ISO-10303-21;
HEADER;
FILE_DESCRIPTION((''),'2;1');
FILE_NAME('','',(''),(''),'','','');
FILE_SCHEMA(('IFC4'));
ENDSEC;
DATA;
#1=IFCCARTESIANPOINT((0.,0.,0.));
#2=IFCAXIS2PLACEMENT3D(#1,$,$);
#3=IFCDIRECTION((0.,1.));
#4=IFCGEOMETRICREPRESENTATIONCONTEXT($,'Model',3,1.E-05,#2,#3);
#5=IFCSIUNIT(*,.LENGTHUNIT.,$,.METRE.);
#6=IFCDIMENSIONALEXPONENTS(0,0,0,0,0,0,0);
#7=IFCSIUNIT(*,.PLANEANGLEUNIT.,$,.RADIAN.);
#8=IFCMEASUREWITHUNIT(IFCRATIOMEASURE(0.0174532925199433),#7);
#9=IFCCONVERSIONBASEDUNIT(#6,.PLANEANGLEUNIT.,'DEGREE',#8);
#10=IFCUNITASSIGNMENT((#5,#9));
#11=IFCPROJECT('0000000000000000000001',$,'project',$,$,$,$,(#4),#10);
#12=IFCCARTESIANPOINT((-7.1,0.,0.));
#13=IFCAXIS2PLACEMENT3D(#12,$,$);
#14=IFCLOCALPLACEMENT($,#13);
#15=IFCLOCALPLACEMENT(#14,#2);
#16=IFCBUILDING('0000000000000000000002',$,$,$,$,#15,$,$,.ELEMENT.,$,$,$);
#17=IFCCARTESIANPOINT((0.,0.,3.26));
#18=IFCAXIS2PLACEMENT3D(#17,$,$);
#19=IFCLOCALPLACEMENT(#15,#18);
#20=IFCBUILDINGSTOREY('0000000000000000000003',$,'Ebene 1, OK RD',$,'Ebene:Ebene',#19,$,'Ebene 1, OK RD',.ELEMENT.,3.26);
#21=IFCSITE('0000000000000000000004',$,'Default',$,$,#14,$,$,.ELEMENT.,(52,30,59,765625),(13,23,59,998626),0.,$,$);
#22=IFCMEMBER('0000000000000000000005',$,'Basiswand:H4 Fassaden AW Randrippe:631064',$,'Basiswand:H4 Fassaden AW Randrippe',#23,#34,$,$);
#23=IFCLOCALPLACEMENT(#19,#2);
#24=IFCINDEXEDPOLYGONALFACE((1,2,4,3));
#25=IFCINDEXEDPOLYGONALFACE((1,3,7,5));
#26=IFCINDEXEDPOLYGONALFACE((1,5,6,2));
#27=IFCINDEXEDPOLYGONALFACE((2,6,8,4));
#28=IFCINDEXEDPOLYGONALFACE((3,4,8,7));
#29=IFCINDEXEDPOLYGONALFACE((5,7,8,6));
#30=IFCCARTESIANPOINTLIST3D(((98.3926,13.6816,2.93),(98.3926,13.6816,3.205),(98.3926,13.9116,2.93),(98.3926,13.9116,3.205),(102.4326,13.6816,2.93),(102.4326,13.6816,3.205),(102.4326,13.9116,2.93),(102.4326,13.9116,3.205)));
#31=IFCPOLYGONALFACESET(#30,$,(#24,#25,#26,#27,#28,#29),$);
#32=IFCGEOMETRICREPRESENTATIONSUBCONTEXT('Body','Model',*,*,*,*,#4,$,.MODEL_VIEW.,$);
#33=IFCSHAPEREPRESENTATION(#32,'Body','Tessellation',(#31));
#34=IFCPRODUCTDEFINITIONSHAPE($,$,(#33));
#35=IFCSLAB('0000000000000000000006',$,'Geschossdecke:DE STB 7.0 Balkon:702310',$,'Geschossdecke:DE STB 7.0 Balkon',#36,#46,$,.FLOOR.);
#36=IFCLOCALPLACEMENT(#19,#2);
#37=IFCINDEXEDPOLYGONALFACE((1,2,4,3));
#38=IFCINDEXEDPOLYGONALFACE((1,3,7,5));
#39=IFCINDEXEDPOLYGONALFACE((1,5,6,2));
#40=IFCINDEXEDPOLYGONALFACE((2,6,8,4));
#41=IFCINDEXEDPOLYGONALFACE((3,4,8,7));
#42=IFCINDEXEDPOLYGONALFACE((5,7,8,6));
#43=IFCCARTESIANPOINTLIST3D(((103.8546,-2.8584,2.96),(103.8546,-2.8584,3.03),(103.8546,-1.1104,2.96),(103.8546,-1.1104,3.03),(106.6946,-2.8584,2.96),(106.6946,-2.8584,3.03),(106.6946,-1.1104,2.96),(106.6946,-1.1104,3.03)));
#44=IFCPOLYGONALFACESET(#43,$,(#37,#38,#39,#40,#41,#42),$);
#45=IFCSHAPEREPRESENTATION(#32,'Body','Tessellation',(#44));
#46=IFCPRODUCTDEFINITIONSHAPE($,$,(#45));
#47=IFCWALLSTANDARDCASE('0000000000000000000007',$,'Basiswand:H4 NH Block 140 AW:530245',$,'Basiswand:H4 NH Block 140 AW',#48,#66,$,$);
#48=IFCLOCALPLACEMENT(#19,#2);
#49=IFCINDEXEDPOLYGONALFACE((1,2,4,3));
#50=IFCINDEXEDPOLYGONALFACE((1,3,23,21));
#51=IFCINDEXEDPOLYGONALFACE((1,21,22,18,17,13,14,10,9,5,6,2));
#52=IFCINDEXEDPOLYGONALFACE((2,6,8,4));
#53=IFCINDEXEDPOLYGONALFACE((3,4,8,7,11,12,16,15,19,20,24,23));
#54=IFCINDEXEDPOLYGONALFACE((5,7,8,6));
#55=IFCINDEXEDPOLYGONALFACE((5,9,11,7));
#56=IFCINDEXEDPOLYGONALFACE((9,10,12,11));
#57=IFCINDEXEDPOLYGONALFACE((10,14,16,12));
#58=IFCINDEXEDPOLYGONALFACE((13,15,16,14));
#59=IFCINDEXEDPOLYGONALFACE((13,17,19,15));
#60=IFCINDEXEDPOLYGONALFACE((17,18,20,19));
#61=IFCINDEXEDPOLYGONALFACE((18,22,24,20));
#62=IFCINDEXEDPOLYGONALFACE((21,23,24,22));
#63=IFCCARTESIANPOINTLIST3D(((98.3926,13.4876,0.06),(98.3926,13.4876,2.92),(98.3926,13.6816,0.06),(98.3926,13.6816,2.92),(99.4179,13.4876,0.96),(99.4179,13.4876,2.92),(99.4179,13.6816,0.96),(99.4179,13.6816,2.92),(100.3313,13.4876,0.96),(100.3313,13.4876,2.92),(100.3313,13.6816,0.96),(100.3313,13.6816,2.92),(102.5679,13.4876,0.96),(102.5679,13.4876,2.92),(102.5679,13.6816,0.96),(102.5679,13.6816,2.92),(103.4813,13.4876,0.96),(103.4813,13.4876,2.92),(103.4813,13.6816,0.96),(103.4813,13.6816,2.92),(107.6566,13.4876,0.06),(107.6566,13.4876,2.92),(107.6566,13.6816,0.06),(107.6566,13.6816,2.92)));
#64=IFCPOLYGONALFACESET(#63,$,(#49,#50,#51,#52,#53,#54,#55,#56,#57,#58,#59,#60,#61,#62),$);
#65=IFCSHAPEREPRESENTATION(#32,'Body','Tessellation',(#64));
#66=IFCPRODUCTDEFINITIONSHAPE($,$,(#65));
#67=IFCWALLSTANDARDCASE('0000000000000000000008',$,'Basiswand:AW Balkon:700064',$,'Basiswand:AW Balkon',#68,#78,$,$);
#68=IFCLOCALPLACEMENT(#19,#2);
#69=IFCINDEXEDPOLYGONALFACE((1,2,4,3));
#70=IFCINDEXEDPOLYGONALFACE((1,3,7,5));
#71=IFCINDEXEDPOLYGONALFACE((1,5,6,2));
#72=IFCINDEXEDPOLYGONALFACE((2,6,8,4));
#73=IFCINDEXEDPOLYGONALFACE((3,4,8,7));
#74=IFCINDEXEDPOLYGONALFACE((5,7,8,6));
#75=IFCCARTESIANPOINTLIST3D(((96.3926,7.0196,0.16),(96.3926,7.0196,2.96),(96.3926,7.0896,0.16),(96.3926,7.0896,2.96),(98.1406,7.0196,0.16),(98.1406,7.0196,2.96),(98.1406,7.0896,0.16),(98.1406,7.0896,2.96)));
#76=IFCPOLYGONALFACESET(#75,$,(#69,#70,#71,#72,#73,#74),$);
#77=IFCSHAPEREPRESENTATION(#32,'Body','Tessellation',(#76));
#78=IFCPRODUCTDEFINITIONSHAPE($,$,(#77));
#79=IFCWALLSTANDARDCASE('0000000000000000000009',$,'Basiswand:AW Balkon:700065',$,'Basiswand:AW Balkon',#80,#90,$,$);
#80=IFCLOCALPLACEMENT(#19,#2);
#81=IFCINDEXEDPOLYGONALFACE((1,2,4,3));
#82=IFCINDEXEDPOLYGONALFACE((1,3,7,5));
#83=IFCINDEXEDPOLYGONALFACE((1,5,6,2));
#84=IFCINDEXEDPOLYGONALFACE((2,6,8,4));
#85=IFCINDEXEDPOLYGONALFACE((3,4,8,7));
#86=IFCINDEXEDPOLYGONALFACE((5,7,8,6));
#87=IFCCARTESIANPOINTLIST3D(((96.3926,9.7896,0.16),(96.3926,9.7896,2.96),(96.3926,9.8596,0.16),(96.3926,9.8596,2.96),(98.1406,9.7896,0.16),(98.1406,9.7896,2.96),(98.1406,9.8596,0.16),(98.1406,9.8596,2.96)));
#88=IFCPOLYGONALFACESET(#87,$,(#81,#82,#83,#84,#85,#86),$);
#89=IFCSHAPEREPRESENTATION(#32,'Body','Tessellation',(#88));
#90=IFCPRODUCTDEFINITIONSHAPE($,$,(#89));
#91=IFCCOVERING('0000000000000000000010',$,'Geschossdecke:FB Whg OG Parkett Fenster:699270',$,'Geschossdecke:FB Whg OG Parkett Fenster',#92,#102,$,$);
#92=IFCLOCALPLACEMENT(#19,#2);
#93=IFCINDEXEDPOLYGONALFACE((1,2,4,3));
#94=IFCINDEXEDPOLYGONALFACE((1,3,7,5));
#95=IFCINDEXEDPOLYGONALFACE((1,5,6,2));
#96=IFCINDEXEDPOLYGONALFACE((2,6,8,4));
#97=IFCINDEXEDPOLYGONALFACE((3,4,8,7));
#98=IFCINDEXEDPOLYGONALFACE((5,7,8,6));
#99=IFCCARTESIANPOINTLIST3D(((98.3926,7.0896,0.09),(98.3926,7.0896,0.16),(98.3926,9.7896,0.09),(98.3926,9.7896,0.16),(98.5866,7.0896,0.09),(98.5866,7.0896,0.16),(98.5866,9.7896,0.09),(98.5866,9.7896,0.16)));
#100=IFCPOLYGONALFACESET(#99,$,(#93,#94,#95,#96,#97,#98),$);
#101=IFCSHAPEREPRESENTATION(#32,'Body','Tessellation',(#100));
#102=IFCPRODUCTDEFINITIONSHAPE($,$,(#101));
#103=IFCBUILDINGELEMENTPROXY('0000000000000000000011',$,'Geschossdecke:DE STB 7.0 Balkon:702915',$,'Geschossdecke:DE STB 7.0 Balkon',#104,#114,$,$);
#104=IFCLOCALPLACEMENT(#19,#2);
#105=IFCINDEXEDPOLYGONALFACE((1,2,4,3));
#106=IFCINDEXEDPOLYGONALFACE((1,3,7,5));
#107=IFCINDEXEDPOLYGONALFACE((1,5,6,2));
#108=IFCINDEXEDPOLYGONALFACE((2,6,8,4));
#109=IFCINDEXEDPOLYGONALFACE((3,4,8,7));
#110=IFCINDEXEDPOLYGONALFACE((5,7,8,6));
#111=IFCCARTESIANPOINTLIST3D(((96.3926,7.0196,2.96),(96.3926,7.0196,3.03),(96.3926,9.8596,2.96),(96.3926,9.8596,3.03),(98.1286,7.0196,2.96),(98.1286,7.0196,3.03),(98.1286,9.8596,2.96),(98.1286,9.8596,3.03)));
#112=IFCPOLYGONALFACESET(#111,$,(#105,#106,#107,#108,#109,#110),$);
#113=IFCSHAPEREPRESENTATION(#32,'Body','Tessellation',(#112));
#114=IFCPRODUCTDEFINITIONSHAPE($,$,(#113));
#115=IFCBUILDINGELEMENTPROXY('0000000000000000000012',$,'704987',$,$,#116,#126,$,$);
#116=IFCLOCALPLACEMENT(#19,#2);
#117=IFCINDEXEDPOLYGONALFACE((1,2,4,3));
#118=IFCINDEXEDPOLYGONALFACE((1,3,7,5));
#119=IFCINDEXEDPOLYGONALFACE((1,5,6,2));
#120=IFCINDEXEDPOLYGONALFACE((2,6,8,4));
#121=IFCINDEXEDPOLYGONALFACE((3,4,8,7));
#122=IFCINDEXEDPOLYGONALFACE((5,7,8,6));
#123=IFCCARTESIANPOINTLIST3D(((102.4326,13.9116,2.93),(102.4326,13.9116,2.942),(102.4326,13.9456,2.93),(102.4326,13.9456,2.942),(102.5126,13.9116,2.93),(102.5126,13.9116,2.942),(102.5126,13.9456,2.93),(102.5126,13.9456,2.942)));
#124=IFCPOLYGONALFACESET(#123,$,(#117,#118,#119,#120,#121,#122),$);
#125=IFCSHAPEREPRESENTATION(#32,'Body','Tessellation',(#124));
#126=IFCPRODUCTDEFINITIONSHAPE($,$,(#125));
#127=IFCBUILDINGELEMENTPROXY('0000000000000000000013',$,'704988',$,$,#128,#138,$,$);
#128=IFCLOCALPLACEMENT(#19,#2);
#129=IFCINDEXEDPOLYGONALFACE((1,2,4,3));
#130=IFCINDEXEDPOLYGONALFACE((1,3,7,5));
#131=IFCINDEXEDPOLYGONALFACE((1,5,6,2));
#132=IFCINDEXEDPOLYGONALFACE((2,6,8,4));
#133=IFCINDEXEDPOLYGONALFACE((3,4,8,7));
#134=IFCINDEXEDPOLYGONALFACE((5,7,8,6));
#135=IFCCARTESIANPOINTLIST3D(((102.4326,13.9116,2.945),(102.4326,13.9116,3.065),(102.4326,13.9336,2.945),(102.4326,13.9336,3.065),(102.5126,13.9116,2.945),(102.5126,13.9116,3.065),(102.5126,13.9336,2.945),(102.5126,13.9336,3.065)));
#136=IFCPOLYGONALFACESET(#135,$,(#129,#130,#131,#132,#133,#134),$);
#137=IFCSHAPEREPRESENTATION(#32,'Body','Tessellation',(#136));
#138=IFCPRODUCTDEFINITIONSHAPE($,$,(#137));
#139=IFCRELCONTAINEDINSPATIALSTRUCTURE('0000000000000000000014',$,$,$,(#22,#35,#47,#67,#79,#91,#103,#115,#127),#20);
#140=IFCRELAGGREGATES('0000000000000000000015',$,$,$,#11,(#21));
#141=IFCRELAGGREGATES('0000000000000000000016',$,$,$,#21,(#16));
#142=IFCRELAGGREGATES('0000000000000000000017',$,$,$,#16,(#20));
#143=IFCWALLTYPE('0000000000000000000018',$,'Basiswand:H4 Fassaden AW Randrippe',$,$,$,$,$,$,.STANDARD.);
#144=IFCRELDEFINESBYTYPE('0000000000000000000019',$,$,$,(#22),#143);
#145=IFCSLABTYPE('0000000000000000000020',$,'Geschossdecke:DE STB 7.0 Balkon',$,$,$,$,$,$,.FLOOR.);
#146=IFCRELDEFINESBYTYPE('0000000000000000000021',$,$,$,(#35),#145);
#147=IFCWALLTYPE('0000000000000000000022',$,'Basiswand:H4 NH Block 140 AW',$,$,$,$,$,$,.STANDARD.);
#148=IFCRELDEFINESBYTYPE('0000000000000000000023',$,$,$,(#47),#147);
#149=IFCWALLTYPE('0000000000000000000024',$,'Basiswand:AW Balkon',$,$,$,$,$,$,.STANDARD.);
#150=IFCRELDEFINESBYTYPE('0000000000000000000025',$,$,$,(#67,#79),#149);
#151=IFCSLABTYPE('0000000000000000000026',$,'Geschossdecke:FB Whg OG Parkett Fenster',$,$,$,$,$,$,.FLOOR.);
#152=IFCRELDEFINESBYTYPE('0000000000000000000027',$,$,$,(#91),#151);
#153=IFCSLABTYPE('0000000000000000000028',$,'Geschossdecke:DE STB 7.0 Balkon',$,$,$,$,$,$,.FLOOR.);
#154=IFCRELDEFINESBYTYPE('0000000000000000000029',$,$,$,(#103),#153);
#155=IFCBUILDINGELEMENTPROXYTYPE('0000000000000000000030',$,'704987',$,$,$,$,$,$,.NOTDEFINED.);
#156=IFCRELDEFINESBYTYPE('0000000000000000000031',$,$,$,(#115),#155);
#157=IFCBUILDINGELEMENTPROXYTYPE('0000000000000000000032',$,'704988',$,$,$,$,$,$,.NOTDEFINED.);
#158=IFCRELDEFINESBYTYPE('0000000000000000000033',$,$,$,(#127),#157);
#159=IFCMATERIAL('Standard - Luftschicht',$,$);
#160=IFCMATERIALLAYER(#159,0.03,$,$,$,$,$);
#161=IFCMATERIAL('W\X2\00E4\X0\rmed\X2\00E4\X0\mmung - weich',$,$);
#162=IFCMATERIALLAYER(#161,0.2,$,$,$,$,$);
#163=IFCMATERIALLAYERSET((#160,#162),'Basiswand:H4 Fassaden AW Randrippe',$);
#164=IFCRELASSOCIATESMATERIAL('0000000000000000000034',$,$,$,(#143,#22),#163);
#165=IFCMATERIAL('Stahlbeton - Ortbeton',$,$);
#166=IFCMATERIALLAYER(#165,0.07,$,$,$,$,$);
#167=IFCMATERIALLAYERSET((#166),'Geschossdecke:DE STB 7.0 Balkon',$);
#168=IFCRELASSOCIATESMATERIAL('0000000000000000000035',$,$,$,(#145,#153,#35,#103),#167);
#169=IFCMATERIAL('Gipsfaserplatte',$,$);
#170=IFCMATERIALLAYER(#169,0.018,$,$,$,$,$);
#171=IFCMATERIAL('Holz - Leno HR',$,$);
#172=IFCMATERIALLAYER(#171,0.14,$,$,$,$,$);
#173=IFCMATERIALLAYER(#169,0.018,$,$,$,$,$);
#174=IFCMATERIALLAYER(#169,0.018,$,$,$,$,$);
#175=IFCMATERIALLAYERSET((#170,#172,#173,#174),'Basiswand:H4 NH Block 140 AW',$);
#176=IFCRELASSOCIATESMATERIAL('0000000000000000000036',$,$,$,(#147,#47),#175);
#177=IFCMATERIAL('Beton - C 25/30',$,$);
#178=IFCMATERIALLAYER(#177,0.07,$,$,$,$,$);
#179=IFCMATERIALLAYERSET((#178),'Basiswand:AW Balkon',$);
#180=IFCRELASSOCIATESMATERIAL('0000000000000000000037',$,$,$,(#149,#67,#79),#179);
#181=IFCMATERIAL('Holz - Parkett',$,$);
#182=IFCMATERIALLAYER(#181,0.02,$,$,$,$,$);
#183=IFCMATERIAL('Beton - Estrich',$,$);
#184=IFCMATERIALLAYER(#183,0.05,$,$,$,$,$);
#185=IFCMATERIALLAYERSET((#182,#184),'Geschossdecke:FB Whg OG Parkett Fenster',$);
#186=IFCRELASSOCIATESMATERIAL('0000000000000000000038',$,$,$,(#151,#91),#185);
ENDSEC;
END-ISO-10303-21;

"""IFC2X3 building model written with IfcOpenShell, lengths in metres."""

from ifc_helpers import new_model, entity, si_unit, converted_unit, direction, frame, frame_2d, origin, origin_2d_with_axis, place, context, subcontext, project, spatial, rectangle, extrude, material, layer, layer_set, layer_usage, type_object, element, save


model = new_model("IFC2X3")

# Units and contexts
model_context = context("Model", 3, precision=1e-05, world=origin(), true_north=direction((0.0, 1.0)))
body_context = subcontext(model_context, "Body", "Model", "MODEL_VIEW")
ifc_project = project(units=[si_unit("LENGTHUNIT", "METRE"), converted_unit("PLANEANGLEUNIT", "DEGREE", entity("IfcRatioMeasure", 0.0174532925199433), si_unit("PLANEANGLEUNIT", "RADIAN"), dimensions=[0, 0, 0, 0, 0, 0, 0])], contexts=[model_context])

# Site, building, storey
site_placement = place(None, frame((-7.1, 0.0, 0.0)))
site = spatial("IfcSite", under=ifc_project, at=site_placement, Name="Default", CompositionType="ELEMENT", RefLatitude=(52, 30, 59, 765625), RefLongitude=(13, 23, 59, 998626), RefElevation=0.0)
building_placement = place(site_placement, origin())
building = spatial("IfcBuilding", under=site, at=building_placement, CompositionType="ELEMENT")
storey_placement = place(building_placement, frame((0.0, 0.0, 3.26)))
storey = spatial("IfcBuildingStorey", under=building, at=storey_placement, Name="Ebene 1, OK RD", ObjectType="Ebene:Ebene", LongName="Ebene 1, OK RD", CompositionType="ELEMENT", Elevation=3.26)

# Shared definitions
ifc_material_1 = material(Name="Gipsfaserplatte")

# Member
ifc_material_2 = material(Name="Standard - Luftschicht")
ifc_layer_1 = layer(ifc_material_2, 0.03)
ifc_material_3 = material(Name="Wärmedämmung - weich")
ifc_layer_2 = layer(ifc_material_3, 0.2)
ifc_layer_set_1 = layer_set([ifc_layer_1, ifc_layer_2], Name="Basiswand:H4 Fassaden AW Randrippe")
ifc_layer_usage_1 = layer_usage(ifc_layer_set_1, "AXIS2", "NEGATIVE", 0.115)
wall_type_1 = type_object("IfcWallType", Name="Basiswand:H4 Fassaden AW Randrippe", PredefinedType="STANDARD", material=ifc_layer_set_1)
member_1_placement = place(storey_placement, frame((98.3926, 13.7966, 2.93)))
element("IfcMember", 1, at=member_1_placement, inside=storey, type_object=wall_type_1, material=ifc_layer_usage_1, Name="Basiswand:H4 Fassaden AW Randrippe:631064", ObjectType="Basiswand:H4 Fassaden AW Randrippe", context=body_context, shape_type="SweptSolid", body=[
    extrude(rectangle(XDim=4.04, YDim=0.23, at=frame_2d((2.02, 0.0), x_axis=(-1.0, 0.0))), origin(), (0.0, 0.0, 1.0), 0.275),
])

# Slab
ifc_material_4 = material(Name="Stahlbeton - Ortbeton")
ifc_layer_3 = layer(ifc_material_4, 0.07)
ifc_layer_set_2 = layer_set([ifc_layer_3], Name="Geschossdecke:DE STB 7.0 Balkon")
ifc_layer_usage_2 = layer_usage(ifc_layer_set_2, "AXIS3", "POSITIVE", 0.0)
slab_type_1 = type_object("IfcSlabType", Name="Geschossdecke:DE STB 7.0 Balkon", PredefinedType="FLOOR", material=ifc_layer_set_2)
slab_1_placement = place(storey_placement, origin())
element("IfcSlab", 2, at=slab_1_placement, inside=storey, type_object=slab_type_1, material=ifc_layer_usage_2, Name="Geschossdecke:DE STB 7.0 Balkon:702310", ObjectType="Geschossdecke:DE STB 7.0 Balkon", PredefinedType="FLOOR", context=body_context, shape_type="SweptSolid", body=[
    extrude(rectangle(XDim=1.748, YDim=2.84, at=frame_2d((0.0, 0.0), x_axis=(1.0, 0.0))), frame((105.2746, -1.9844, 3.03), z_axis=(0.0, 0.0, -1.0), x_axis=(0.0, 1.0, 0.0)), (0.0, 0.0, 1.0), 0.07),
])

# Wall, openings
ifc_layer_4 = layer(ifc_material_1, 0.018)
ifc_material_5 = material(Name="Holz - Leno HR")
ifc_layer_5 = layer(ifc_material_5, 0.14)
ifc_layer_6 = layer(ifc_material_1, 0.018)
ifc_layer_7 = layer(ifc_material_1, 0.018)
ifc_layer_set_3 = layer_set([ifc_layer_4, ifc_layer_5, ifc_layer_6, ifc_layer_7], Name="Basiswand:H4 NH Block 140 AW")
ifc_layer_usage_3 = layer_usage(ifc_layer_set_3, "AXIS2", "NEGATIVE", 0.097)
wall_type_2 = type_object("IfcWallType", Name="Basiswand:H4 NH Block 140 AW", PredefinedType="STANDARD", material=ifc_layer_set_3)
wall_1_placement = place(storey_placement, frame((98.3926, 13.5846, 0.06)))
wall_1 = element("IfcWallStandardCase", 3, at=wall_1_placement, inside=storey, type_object=wall_type_2, material=ifc_layer_usage_3, Name="Basiswand:H4 NH Block 140 AW:530245", ObjectType="Basiswand:H4 NH Block 140 AW", context=body_context, shape_type="SweptSolid", body=[
    extrude(rectangle(XDim=9.264, YDim=0.194, at=frame_2d((4.632, 0.0), x_axis=(-1.0, 0.0))), origin(), (0.0, 0.0, 1.0), 2.86),
])
opening_1_placement = place(wall_1_placement, origin())
element("IfcOpeningElement", 4, at=opening_1_placement, cuts=wall_1, ObjectType="Opening", context=body_context, shape_type="SweptSolid", body=[
    extrude(rectangle(XDim=2.0, YDim=0.9134, at=origin_2d_with_axis()), frame((1.482, -0.097, 1.9), z_axis=(0.0, 1.0, 0.0), x_axis=(0.0, 0.0, -1.0)), (0.0, 0.0, 1.0), 0.194),
])
opening_2_placement = place(wall_1_placement, origin())
element("IfcOpeningElement", 5, at=opening_2_placement, cuts=wall_1, ObjectType="Opening", context=body_context, shape_type="SweptSolid", body=[
    extrude(rectangle(XDim=2.0, YDim=0.9134, at=origin_2d_with_axis()), frame((4.632, -0.097, 1.9), z_axis=(0.0, 1.0, 0.0), x_axis=(0.0, 0.0, -1.0)), (0.0, 0.0, 1.0), 0.194),
])

# Walls
ifc_material_6 = material(Name="Beton - C 25/30")
ifc_layer_8 = layer(ifc_material_6, 0.07)
ifc_layer_set_4 = layer_set([ifc_layer_8], Name="Basiswand:AW Balkon")
ifc_layer_usage_4 = layer_usage(ifc_layer_set_4, "AXIS2", "NEGATIVE", 0.035)
wall_type_3 = type_object("IfcWallType", Name="Basiswand:AW Balkon", PredefinedType="STANDARD", material=ifc_layer_set_4)
wall_2_placement = place(storey_placement, frame((98.1406, 7.0546, 0.16), z_axis=(0.0, 0.0, 1.0), x_axis=(-1.0, 0.0, 0.0)))
element("IfcWallStandardCase", 6, at=wall_2_placement, inside=storey, type_object=wall_type_3, material=ifc_layer_usage_4, Name="Basiswand:AW Balkon:700064", ObjectType="Basiswand:AW Balkon", context=body_context, shape_type="SweptSolid", body=[
    extrude(rectangle(XDim=1.748, YDim=0.07, at=frame_2d((0.874, 0.0), x_axis=(-1.0, 0.0))), origin(), (0.0, 0.0, 1.0), 2.8),
])
ifc_layer_usage_5 = layer_usage(ifc_layer_set_4, "AXIS2", "NEGATIVE", 0.035)
wall_3_placement = place(storey_placement, frame((96.3926, 9.8246, 0.16)))
element("IfcWallStandardCase", 7, at=wall_3_placement, inside=storey, type_object=wall_type_3, material=ifc_layer_usage_5, Name="Basiswand:AW Balkon:700065", ObjectType="Basiswand:AW Balkon", context=body_context, shape_type="SweptSolid", body=[
    extrude(rectangle(XDim=1.748, YDim=0.07, at=frame_2d((0.874, 0.0), x_axis=(-1.0, 0.0))), origin(), (0.0, 0.0, 1.0), 2.8),
])

# Covering
ifc_material_7 = material(Name="Holz - Parkett")
ifc_layer_9 = layer(ifc_material_7, 0.02)
ifc_material_8 = material(Name="Beton - Estrich")
ifc_layer_10 = layer(ifc_material_8, 0.05)
ifc_layer_set_5 = layer_set([ifc_layer_9, ifc_layer_10], Name="Geschossdecke:FB Whg OG Parkett Fenster")
ifc_layer_usage_6 = layer_usage(ifc_layer_set_5, "AXIS3", "POSITIVE", 0.0)
slab_type_2 = type_object("IfcSlabType", Name="Geschossdecke:FB Whg OG Parkett Fenster", PredefinedType="FLOOR", material=ifc_layer_set_5)
covering_placement = place(storey_placement, origin())
element("IfcCovering", 8, at=covering_placement, inside=storey, type_object=slab_type_2, material=ifc_layer_usage_6, Name="Geschossdecke:FB Whg OG Parkett Fenster:699270", ObjectType="Geschossdecke:FB Whg OG Parkett Fenster", context=body_context, shape_type="SweptSolid", body=[
    extrude(rectangle(XDim=2.7, YDim=0.194, at=origin_2d_with_axis()), frame((98.4896, 8.4396, 0.16), z_axis=(0.0, 0.0, -1.0), x_axis=(0.0, 1.0, 0.0)), (0.0, 0.0, 1.0), 0.07),
])

# Building element proxies
ifc_layer_usage_7 = layer_usage(ifc_layer_set_2, "AXIS3", "POSITIVE", 0.0)
slab_type_3 = type_object("IfcSlabType", Name="Geschossdecke:DE STB 7.0 Balkon", PredefinedType="FLOOR", material=ifc_layer_set_2)
proxy_1_placement = place(storey_placement, origin())
element("IfcBuildingElementProxy", 9, at=proxy_1_placement, inside=storey, type_object=slab_type_3, material=ifc_layer_usage_7, Name="Geschossdecke:DE STB 7.0 Balkon:702915", ObjectType="Geschossdecke:DE STB 7.0 Balkon", context=body_context, shape_type="SweptSolid", body=[
    extrude(rectangle(XDim=2.84, YDim=1.736, at=origin_2d_with_axis()), frame((97.2606, 8.4396, 3.03), z_axis=(0.0, 0.0, -1.0), x_axis=(0.0, 1.0, 0.0)), (0.0, 0.0, 1.0), 0.07),
])
building_element_proxy_type_1 = type_object("IfcBuildingElementProxyType", Name="704987", PredefinedType="NOTDEFINED")
proxy_2_placement = place(storey_placement, origin())
element("IfcBuildingElementProxy", 10, at=proxy_2_placement, inside=storey, type_object=building_element_proxy_type_1, Name="704987", context=body_context, shape_type="SweptSolid", body=[
    extrude(rectangle(XDim=0.08, YDim=0.034, at=frame_2d((0.0, 0.0), x_axis=(1.0, 0.0))), frame((102.4726, 13.9286, 2.93)), (0.0, 0.0, 1.0), 0.012),
])
building_element_proxy_type_2 = type_object("IfcBuildingElementProxyType", Name="704988", PredefinedType="NOTDEFINED")
proxy_3_placement = place(storey_placement, origin())
element("IfcBuildingElementProxy", 11, at=proxy_3_placement, inside=storey, type_object=building_element_proxy_type_2, Name="704988", context=body_context, shape_type="SweptSolid", body=[
    extrude(rectangle(XDim=0.08, YDim=0.022, at=frame_2d((0.0, 0.0), x_axis=(1.0, 0.0))), frame((102.4726, 13.9226, 2.945)), (0.0, 0.0, 1.0), 0.12),
])

save(model, "model.ifc")
